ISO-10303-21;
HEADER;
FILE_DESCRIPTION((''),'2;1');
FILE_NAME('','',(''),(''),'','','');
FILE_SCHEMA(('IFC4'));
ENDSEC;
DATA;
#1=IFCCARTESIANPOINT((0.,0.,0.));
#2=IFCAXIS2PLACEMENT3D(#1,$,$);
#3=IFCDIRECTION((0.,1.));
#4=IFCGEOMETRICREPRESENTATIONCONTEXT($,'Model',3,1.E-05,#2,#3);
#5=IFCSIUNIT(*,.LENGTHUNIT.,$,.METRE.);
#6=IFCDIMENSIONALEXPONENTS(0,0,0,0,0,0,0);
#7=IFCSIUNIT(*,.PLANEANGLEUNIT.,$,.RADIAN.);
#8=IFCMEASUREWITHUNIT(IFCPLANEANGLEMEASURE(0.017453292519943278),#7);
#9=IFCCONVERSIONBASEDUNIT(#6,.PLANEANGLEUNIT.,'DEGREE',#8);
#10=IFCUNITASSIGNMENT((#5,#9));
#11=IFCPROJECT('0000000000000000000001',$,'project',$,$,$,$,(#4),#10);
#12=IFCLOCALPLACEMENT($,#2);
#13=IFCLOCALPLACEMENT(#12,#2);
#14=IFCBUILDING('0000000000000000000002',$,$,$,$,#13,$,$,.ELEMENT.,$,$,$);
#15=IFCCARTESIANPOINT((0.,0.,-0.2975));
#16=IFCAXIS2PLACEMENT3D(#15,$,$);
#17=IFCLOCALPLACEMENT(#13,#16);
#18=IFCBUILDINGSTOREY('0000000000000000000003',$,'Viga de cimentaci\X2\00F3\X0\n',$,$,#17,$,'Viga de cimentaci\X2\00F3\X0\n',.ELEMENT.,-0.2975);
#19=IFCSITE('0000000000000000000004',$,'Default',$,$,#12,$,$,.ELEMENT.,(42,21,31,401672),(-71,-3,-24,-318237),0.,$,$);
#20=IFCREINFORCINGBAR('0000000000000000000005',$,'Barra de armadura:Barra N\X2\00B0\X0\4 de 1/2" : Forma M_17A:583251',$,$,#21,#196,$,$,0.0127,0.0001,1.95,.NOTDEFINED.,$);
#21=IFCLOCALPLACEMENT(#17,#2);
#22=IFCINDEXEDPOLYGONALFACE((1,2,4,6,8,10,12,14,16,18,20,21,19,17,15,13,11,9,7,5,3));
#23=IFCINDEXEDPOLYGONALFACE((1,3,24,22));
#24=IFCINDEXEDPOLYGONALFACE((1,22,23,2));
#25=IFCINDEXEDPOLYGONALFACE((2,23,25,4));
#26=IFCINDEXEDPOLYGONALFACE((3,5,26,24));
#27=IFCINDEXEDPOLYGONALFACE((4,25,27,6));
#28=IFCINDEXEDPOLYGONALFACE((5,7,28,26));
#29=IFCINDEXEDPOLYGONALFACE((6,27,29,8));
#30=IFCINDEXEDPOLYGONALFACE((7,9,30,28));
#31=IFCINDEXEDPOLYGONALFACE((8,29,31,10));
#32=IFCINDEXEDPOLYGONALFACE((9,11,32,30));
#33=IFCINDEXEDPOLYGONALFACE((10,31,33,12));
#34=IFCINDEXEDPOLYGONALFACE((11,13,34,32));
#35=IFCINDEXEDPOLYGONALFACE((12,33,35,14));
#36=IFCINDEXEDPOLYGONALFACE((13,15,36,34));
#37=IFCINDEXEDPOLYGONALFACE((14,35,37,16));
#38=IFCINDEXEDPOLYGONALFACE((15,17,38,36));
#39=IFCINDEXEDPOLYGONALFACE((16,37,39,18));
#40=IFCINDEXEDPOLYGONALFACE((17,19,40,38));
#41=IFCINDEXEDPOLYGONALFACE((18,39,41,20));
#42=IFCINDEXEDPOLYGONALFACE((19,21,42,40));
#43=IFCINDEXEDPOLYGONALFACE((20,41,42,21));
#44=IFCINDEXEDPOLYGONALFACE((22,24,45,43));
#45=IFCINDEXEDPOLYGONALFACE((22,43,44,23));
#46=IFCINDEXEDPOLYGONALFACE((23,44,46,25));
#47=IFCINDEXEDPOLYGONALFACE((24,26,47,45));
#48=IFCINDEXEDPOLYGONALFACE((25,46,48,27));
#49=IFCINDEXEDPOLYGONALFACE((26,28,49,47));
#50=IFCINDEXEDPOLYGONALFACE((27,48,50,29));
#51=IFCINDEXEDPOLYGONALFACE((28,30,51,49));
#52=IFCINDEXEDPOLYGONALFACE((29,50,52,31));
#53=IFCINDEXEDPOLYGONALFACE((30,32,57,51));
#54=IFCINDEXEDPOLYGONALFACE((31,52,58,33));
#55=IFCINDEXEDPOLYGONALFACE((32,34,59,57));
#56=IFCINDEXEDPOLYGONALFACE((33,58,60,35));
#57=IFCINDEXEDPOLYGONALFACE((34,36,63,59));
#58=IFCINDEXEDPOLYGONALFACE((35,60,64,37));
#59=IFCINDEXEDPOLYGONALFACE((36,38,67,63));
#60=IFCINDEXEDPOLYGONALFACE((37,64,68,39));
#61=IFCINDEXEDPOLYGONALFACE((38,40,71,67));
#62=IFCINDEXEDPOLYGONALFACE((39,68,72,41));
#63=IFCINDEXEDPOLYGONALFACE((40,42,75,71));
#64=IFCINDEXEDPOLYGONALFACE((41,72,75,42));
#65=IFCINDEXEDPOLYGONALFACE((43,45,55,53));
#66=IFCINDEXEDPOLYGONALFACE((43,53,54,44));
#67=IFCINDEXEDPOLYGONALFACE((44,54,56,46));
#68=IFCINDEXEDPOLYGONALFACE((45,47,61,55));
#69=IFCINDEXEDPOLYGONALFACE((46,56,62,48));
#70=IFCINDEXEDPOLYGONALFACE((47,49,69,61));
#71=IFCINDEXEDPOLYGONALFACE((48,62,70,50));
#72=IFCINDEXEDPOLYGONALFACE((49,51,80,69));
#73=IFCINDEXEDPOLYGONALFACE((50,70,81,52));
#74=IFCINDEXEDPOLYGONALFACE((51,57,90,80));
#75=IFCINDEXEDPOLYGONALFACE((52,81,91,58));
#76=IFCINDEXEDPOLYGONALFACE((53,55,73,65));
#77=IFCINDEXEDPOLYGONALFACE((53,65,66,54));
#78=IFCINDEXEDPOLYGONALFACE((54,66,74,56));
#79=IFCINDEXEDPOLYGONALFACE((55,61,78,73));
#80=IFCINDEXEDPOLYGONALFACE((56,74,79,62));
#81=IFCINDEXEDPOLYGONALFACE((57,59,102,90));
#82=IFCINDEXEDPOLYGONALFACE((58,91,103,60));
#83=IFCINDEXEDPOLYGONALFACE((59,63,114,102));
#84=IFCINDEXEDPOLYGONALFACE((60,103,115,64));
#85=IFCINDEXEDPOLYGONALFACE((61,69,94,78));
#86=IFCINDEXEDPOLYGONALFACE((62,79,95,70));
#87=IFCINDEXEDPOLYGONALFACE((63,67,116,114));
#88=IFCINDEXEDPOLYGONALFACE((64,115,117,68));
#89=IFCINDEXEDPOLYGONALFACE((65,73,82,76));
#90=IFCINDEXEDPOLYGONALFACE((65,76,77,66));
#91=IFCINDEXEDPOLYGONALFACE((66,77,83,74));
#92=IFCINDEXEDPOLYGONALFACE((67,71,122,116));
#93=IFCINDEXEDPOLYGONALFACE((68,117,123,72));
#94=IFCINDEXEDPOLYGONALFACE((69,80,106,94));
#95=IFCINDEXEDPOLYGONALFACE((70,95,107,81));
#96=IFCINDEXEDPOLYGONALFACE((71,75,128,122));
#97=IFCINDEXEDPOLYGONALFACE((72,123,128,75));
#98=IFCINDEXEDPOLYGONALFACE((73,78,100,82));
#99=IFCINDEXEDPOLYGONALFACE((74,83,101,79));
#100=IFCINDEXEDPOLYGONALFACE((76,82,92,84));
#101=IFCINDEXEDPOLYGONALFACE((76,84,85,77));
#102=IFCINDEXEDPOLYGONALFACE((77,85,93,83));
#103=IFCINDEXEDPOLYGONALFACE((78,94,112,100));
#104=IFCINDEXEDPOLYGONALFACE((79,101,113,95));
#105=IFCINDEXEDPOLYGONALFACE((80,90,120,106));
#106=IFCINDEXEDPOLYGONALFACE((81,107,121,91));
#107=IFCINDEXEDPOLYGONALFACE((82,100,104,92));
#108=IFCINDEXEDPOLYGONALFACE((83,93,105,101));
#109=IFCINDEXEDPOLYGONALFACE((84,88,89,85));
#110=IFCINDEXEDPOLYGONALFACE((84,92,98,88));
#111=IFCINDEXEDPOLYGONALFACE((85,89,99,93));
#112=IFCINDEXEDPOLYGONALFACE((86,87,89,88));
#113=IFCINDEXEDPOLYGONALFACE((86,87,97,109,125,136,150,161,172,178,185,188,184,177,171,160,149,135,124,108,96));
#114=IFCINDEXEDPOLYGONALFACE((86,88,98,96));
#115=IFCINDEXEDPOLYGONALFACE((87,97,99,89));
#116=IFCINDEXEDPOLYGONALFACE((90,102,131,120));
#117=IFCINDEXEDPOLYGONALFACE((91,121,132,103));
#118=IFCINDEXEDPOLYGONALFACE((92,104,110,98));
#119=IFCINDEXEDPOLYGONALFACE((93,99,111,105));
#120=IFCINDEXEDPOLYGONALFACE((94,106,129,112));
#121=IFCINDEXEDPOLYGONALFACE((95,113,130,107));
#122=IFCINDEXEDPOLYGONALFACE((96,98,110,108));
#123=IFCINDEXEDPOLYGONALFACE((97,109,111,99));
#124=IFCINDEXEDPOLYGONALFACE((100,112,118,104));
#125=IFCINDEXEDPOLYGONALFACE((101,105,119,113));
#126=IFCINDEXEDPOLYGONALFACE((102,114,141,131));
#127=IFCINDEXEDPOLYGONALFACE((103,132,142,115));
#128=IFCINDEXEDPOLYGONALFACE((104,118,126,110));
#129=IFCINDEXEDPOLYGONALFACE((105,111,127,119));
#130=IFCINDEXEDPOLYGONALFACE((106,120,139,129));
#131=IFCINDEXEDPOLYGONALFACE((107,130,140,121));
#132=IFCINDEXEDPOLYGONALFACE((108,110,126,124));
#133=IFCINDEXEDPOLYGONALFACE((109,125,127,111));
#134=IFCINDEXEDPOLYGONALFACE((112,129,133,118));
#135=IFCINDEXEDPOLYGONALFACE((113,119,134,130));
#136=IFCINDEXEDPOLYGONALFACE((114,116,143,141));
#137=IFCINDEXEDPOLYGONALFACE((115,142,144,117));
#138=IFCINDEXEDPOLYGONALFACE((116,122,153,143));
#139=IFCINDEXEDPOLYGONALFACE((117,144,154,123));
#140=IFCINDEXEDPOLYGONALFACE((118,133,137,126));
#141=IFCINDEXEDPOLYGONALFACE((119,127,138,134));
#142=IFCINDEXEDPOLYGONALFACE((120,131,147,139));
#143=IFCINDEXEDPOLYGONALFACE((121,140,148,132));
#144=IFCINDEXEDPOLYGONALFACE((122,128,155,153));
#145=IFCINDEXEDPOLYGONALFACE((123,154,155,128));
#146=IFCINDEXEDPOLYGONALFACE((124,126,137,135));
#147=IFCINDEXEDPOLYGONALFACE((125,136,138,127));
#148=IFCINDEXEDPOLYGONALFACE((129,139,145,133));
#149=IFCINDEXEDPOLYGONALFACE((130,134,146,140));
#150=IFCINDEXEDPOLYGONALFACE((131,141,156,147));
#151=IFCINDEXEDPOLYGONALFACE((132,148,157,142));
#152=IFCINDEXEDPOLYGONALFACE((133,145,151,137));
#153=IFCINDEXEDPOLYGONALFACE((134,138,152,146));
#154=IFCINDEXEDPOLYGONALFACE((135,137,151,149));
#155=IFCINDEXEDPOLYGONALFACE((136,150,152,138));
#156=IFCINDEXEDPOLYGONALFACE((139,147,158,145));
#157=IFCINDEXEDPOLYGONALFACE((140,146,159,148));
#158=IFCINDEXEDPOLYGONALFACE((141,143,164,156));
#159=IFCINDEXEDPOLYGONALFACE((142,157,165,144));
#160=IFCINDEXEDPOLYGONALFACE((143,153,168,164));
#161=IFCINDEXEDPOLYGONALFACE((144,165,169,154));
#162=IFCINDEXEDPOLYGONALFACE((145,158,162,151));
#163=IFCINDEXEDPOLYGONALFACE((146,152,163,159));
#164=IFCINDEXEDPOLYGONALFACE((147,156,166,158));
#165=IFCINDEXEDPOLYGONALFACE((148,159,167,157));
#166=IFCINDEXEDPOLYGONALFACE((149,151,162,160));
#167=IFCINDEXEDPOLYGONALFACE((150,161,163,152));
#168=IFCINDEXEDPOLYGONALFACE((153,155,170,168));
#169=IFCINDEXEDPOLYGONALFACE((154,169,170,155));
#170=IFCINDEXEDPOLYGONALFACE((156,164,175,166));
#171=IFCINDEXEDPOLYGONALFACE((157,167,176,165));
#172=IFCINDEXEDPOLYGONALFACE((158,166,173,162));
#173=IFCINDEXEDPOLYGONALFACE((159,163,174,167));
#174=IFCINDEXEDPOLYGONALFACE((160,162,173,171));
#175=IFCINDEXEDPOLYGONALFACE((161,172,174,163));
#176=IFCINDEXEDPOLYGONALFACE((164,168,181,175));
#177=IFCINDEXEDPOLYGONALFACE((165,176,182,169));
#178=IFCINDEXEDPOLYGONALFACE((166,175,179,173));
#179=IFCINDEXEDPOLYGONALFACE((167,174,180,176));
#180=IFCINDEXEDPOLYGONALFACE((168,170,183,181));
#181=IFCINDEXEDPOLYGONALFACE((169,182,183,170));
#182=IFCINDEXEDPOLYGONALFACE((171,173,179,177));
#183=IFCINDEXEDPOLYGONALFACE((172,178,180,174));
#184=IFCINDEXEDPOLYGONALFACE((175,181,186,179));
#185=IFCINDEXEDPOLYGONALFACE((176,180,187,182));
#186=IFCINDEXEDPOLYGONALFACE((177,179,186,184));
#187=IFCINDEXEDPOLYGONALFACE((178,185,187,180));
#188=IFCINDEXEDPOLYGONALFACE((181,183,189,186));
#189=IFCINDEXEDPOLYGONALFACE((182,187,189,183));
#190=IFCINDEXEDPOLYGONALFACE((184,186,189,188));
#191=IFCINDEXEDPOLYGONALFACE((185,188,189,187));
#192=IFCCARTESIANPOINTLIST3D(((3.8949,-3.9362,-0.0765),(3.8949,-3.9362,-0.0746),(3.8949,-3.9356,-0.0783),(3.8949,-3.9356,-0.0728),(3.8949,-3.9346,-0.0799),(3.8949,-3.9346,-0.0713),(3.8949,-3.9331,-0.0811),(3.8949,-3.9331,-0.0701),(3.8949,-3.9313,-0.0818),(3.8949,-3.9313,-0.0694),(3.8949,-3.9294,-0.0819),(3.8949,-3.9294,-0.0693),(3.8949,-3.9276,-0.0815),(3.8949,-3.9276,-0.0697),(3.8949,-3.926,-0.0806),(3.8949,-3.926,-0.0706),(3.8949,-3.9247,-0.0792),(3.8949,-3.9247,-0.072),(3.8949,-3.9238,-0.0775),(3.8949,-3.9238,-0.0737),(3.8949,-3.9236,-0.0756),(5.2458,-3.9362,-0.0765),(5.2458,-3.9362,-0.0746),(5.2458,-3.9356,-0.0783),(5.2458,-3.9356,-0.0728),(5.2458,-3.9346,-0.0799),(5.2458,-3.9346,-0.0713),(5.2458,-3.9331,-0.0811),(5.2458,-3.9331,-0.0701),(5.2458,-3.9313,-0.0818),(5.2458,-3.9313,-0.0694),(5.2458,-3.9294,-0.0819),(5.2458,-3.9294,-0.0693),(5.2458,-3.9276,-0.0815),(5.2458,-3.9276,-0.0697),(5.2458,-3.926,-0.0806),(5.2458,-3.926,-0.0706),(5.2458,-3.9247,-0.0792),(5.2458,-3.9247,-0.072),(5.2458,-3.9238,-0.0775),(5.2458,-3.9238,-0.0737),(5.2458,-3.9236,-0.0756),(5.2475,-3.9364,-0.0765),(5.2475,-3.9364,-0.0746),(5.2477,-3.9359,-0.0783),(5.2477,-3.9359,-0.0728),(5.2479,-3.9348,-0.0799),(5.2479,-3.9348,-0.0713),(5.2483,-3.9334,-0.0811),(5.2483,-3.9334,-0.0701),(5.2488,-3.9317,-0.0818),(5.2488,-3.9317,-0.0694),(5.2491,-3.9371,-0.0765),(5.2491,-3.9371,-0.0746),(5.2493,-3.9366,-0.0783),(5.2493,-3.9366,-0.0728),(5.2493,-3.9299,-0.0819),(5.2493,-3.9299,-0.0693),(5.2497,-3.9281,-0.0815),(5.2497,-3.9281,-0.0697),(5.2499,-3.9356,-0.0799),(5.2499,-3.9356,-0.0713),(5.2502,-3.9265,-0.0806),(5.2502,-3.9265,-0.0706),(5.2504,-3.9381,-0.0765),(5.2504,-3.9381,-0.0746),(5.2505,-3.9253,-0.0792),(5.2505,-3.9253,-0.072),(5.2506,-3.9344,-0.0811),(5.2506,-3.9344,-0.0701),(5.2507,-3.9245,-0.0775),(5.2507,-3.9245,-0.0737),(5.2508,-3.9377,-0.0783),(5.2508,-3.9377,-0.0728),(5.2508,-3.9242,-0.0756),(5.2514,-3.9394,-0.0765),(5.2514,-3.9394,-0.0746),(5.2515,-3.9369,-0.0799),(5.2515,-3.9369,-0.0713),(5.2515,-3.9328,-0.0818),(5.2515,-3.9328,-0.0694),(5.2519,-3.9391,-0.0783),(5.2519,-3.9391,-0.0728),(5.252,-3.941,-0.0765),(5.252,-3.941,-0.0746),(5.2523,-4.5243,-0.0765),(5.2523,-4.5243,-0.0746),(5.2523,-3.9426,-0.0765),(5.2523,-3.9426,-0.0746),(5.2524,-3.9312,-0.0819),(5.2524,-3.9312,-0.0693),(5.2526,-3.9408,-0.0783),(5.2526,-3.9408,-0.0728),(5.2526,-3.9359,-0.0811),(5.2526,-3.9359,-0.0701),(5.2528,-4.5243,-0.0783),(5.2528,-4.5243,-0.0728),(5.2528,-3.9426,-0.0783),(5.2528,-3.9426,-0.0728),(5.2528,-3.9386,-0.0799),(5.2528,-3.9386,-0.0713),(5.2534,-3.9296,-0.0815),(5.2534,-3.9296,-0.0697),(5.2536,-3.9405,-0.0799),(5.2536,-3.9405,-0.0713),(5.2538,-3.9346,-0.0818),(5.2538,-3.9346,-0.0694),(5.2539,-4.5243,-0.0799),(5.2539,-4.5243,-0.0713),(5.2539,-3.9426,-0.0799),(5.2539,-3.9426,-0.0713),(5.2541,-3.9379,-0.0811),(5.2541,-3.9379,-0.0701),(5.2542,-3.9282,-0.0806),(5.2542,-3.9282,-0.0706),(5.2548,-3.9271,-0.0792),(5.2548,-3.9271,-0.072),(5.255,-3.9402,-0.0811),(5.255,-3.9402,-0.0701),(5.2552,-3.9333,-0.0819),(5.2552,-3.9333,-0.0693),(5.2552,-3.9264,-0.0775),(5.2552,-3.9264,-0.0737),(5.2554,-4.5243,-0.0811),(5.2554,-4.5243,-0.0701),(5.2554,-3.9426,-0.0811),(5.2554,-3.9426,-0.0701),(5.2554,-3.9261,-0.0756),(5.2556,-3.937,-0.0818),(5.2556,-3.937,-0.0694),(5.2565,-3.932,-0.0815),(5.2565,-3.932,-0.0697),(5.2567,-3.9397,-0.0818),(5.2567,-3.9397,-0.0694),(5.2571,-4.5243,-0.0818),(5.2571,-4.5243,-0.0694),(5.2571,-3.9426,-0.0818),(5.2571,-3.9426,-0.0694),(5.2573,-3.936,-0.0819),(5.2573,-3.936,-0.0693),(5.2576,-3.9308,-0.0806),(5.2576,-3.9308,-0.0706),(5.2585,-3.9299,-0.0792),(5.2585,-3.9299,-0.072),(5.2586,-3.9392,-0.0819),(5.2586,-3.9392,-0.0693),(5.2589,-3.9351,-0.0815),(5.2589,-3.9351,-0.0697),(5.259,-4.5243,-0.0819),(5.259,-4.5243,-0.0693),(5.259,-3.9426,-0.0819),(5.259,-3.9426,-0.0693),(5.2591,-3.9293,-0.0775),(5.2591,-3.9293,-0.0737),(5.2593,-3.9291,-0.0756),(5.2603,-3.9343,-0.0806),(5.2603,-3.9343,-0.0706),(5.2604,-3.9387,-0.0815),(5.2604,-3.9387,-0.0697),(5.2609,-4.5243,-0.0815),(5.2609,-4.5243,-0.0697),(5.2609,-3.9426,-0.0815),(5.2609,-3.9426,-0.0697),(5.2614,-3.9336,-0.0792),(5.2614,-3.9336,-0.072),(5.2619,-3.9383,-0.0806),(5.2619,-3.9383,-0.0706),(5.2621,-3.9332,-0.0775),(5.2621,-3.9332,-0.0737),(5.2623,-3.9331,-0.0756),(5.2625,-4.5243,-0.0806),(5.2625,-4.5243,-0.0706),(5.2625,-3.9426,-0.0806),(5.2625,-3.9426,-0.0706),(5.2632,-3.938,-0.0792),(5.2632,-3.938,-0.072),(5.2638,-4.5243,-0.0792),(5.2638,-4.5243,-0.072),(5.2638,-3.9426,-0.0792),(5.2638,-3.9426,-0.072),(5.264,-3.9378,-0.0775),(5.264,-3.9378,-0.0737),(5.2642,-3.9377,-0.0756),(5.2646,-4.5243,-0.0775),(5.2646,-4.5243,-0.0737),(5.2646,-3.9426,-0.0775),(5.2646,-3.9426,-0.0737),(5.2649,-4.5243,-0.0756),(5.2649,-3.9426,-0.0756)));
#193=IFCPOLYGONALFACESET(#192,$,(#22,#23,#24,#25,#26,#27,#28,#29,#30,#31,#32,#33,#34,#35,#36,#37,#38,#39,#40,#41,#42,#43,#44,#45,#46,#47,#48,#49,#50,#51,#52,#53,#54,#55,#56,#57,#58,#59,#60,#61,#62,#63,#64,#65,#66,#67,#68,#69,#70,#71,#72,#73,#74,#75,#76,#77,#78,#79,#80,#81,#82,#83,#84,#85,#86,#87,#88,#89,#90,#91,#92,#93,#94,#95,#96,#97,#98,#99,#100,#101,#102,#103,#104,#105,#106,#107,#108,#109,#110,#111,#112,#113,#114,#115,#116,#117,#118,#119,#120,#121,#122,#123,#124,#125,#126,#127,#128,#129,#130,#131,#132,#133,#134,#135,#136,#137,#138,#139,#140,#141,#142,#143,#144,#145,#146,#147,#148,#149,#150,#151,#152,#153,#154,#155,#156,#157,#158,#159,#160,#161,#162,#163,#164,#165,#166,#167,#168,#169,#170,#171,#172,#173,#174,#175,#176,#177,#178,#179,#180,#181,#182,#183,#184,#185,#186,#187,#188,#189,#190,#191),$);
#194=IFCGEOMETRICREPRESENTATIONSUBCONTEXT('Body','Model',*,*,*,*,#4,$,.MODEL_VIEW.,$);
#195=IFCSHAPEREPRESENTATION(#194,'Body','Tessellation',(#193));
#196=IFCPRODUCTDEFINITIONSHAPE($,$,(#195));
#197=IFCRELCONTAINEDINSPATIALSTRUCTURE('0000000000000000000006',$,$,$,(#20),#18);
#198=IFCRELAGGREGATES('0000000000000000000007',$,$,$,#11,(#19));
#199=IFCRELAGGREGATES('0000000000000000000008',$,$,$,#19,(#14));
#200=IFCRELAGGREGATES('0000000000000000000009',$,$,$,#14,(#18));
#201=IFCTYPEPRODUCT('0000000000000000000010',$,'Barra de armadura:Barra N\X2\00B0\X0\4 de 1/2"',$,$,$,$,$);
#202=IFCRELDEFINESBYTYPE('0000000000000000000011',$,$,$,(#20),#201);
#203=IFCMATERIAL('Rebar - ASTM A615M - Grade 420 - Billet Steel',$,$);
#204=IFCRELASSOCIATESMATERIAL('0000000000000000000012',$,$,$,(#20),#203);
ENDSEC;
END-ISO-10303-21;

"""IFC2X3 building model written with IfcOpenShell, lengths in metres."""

from ifc_helpers import new_model, entity, si_unit, converted_unit, direction, frame, origin, place, context, subcontext, project, spatial, material, type_object, element, save


model = new_model("IFC2X3")

# Units and contexts
model_context = context("Model", 3, precision=1e-05, world=origin(), true_north=direction((0.0, 1.0)))
body_context = subcontext(model_context, "Body", "Model", "MODEL_VIEW")
ifc_project = project(units=[si_unit("LENGTHUNIT", "METRE"), converted_unit("PLANEANGLEUNIT", "DEGREE", entity("IfcPlaneAngleMeasure", 0.017453292519943278), si_unit("PLANEANGLEUNIT", "RADIAN"), dimensions=[0, 0, 0, 0, 0, 0, 0])], contexts=[model_context])

# Site, building, storey
site_placement = place(None, origin())
site = spatial("IfcSite", under=ifc_project, at=site_placement, Name="Default", CompositionType="ELEMENT", RefLatitude=(42, 21, 31, 401672), RefLongitude=(-71, -3, -24, -318237), RefElevation=0.0)
building_placement = place(site_placement, origin())
building = spatial("IfcBuilding", under=site, at=building_placement, CompositionType="ELEMENT")
storey_placement = place(building_placement, frame((0.0, 0.0, -0.2975)))
storey = spatial("IfcBuildingStorey", under=building, at=storey_placement, Name="Viga de cimentación", LongName="Viga de cimentación", CompositionType="ELEMENT", Elevation=-0.2975)

# Reinforcing bar
ifc_material = material(Name="Rebar - ASTM A615M - Grade 420 - Billet Steel")
type_product_1 = type_object("IfcTypeProduct", Name="Barra de armadura:Barra N°4 de 1/2\"")
reinforcing_bar_1_placement = place(storey_placement, origin())
element("IfcReinforcingBar", 1, at=reinforcing_bar_1_placement, inside=storey, type_object=type_product_1, material=ifc_material, Name="Barra de armadura:Barra N°4 de 1/2\" : Forma M_17A:583251", BarLength=1.95, BarRole="NOTDEFINED", CrossSectionArea=0.0001, NominalDiameter=0.0127, context=body_context, shape_type="AdvancedSweptSolid", body=[
    entity("IfcSweptDiskSolid", entity("IfcCompositeCurve", [entity("IfcCompositeCurveSegment", "CONTINUOUS", True, entity("IfcPolyline", [entity("IfcCartesianPoint", [5.2585, -4.5243, -0.0756]), entity("IfcCartesianPoint", [5.2585, -3.9426, -0.0756])])), entity("IfcCompositeCurveSegment", "CONTINUOUS", True, entity("IfcTrimmedCurve", entity("IfcCircle", entity("IfcAxis2Placement3D", entity("IfcCartesianPoint", [5.2458, -3.9426, -0.0756]), entity("IfcDirection", [0.0, 0.0, 1.0]), entity("IfcDirection", [0.0, 1.0, 0.0])), 0.0127), [entity("IfcParameterValue", 270.0)], [entity("IfcParameterValue", 360.0)], True, "PARAMETER")), entity("IfcCompositeCurveSegment", "CONTINUOUS", True, entity("IfcPolyline", [entity("IfcCartesianPoint", [5.2458, -3.9299, -0.0756]), entity("IfcCartesianPoint", [3.8949, -3.9299, -0.0756])]))], False), 0.0063, None, 0.0, 92.0),
])

save(model, "model.ifc")
